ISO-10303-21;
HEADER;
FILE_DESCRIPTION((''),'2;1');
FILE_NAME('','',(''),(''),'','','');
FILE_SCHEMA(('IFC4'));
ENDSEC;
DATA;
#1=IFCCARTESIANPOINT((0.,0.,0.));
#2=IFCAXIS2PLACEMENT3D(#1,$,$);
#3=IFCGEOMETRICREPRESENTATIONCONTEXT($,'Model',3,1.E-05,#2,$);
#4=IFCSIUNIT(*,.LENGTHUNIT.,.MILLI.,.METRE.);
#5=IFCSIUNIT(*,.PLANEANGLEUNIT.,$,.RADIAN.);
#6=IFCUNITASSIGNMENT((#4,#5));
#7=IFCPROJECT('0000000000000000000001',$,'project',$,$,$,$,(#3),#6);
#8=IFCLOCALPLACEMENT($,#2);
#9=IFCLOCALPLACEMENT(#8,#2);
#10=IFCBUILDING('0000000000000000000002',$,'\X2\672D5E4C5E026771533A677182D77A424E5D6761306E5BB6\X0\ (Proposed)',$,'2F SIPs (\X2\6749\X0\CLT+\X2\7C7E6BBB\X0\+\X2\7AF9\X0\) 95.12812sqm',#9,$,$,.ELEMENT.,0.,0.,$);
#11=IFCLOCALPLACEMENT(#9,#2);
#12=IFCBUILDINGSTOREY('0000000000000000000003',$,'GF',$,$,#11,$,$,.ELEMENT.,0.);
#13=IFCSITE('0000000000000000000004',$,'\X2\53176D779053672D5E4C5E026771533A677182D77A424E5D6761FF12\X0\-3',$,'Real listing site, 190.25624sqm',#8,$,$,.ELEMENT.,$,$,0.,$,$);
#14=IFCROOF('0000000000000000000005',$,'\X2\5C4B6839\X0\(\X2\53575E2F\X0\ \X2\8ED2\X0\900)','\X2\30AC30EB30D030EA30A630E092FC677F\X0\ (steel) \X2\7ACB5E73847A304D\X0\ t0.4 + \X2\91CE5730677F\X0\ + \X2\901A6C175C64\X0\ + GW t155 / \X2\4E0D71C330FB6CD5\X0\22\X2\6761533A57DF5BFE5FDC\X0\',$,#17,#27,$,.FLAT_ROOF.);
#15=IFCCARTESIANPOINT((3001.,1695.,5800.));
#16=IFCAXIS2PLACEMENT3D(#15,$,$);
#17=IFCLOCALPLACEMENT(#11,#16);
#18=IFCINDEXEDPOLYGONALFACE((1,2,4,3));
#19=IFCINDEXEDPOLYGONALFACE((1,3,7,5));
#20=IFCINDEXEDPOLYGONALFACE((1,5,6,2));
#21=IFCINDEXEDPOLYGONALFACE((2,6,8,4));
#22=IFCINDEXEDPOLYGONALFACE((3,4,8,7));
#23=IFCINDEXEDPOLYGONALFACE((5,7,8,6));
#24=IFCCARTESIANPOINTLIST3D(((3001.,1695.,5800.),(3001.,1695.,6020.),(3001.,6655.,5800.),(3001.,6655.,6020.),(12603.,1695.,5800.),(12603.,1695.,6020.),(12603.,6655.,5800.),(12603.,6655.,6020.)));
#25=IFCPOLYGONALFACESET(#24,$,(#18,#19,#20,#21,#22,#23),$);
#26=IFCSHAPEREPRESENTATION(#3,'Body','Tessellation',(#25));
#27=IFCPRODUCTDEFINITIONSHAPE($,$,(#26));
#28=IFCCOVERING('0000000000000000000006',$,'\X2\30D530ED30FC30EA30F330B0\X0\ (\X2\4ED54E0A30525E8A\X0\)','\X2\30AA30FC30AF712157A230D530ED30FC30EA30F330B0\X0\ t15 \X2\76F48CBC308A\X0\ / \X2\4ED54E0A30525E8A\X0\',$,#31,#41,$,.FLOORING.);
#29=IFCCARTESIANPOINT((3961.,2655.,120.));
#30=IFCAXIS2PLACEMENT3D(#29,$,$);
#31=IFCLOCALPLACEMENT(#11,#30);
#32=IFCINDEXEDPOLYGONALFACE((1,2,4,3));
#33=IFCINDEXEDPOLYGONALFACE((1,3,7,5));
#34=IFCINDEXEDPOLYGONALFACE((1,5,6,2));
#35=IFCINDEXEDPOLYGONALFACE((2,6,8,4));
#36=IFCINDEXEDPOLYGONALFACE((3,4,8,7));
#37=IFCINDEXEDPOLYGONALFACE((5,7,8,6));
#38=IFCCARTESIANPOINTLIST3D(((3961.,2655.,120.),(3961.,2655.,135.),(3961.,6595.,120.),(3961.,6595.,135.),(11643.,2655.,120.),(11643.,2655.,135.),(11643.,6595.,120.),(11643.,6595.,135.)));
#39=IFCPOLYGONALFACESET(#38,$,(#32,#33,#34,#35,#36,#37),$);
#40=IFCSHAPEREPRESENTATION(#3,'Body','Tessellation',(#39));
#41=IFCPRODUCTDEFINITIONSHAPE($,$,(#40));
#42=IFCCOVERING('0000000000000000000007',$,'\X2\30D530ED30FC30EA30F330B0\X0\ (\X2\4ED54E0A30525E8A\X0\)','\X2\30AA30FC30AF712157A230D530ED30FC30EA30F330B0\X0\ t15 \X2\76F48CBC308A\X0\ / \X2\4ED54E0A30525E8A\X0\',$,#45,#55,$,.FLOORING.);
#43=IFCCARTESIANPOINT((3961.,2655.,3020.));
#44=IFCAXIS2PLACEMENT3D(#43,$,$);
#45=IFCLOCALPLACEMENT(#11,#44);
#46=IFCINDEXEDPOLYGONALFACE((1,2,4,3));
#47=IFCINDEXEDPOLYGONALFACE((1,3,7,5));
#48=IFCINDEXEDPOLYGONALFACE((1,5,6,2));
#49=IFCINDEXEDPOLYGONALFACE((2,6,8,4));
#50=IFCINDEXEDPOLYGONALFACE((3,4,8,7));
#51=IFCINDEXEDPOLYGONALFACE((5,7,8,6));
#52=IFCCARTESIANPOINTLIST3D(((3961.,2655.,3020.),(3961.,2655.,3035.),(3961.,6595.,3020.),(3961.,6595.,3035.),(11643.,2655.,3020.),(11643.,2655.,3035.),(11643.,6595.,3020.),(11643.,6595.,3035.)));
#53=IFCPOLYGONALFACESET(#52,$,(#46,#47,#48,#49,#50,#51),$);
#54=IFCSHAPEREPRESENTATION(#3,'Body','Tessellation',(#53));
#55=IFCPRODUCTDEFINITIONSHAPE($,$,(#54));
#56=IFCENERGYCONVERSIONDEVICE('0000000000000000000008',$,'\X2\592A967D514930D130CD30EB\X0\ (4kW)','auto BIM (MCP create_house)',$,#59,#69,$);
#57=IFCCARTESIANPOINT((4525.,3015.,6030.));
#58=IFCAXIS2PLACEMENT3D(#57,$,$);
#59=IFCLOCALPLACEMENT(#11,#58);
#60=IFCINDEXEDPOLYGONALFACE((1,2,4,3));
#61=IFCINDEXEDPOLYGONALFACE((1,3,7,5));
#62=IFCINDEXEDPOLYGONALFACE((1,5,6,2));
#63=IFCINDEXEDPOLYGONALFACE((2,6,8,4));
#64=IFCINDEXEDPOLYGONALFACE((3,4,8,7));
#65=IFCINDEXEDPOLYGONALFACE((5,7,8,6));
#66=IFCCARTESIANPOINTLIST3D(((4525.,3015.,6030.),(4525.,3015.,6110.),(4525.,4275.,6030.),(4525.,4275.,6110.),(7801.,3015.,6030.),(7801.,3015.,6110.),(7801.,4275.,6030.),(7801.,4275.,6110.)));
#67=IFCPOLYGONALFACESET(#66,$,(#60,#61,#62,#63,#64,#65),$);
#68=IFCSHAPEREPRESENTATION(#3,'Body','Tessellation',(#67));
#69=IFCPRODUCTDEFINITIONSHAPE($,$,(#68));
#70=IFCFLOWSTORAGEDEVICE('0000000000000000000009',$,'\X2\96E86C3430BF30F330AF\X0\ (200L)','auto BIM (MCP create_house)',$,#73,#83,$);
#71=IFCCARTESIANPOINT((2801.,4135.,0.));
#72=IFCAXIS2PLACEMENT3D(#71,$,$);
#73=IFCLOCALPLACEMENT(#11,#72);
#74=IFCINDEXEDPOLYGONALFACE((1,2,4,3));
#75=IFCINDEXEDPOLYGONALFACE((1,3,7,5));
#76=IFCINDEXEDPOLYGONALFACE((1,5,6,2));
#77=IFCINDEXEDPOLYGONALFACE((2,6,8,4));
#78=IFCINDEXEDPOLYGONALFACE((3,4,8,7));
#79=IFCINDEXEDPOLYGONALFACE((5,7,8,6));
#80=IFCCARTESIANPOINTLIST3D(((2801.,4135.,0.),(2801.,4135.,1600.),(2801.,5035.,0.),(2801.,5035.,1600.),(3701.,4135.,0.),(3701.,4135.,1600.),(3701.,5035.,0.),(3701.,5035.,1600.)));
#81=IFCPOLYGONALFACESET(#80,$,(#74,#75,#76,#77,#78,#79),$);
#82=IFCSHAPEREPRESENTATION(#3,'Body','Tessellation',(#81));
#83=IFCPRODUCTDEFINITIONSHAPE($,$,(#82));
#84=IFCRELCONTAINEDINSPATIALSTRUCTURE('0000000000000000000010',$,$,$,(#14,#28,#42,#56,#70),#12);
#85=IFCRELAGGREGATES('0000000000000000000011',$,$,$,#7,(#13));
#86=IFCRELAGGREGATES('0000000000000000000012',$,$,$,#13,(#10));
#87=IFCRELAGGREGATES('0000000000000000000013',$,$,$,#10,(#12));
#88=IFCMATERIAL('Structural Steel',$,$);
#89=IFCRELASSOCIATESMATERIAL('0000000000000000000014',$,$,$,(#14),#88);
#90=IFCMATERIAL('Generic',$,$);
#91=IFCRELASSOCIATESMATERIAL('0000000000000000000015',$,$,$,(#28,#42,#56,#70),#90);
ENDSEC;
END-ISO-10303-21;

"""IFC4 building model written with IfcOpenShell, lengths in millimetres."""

from ifc_helpers import new_model, si_unit, frame, frame_2d, origin, place, context, project, spatial, rectangle, extrude, material, element, save


model = new_model("IFC4")

# Units and contexts
model_context = context("Model", 3, precision=1e-05, world=origin())
ifc_project = project(units=[si_unit("LENGTHUNIT", "METRE", prefix="MILLI"), si_unit("PLANEANGLEUNIT", "RADIAN")], contexts=[model_context])

# Site, building, storey
site_placement = place(None, origin())
site = spatial("IfcSite", under=ifc_project, at=site_placement, Name="北海道札幌市東区東苗穂九条２-3", ObjectType="Real listing site, 190.25624sqm", CompositionType="ELEMENT", RefElevation=0.0)
building_placement = place(site_placement, origin())
building = spatial("IfcBuilding", under=site, at=building_placement, Name="札幌市東区東苗穂九条の家 (Proposed)", ObjectType="2F SIPs (杉CLT+籾殻+竹) 95.12812sqm", CompositionType="ELEMENT", ElevationOfRefHeight=0.0, ElevationOfTerrain=0.0)
storey_placement = place(building_placement, origin())
storey = spatial("IfcBuildingStorey", under=building, at=storey_placement, Name="GF", CompositionType="ELEMENT", Elevation=0.0)

# Roof
ifc_material_1 = material(Name="Structural Steel")
for number, where, name in (
    (1, (3001.0, 1695.0, 5800.0), "屋根(南帯 軒900)"),
):
    element("IfcRoof", number, at=place(storey_placement, frame(where)), inside=storey, material=ifc_material_1, Name=name, Description="ガルバリウム鋼板 (steel) 立平葺き t0.4 + 野地板 + 通気層 + GW t155 / 不燃・法22条区域対応", PredefinedType="FLAT_ROOF", context=model_context, shape_type="SweptSolid", body=[
        extrude(rectangle(XDim=9602.0, YDim=4960.0, at=frame_2d((4801.0, 2480.0))), frame((3001.0, 1695.0, 5800.0)), (0.0, 0.0, 1.0), 220.0),
    ])

# Coverings
ifc_material_2 = material(Name="Generic")
covering_1_placement = place(storey_placement, frame((3961.0, 2655.0, 120.0)))
element("IfcCovering", 2, at=covering_1_placement, inside=storey, material=ifc_material_2, Name="フローリング (仕上げ床)", Description="オーク無垢フローリング t15 直貼り / 仕上げ床", PredefinedType="FLOORING", context=model_context, shape_type="SweptSolid", body=[
    extrude(rectangle(XDim=7682.0, YDim=3940.0, at=frame_2d((3841.0, 1970.0))), frame((3961.0, 2655.0, 120.0)), (0.0, 0.0, 1.0), 15.0),
])
covering_2_placement = place(storey_placement, frame((3961.0, 2655.0, 3020.0)))
element("IfcCovering", 3, at=covering_2_placement, inside=storey, material=ifc_material_2, Name="フローリング (仕上げ床)", Description="オーク無垢フローリング t15 直貼り / 仕上げ床", PredefinedType="FLOORING", context=model_context, shape_type="SweptSolid", body=[
    extrude(rectangle(XDim=7682.0, YDim=3940.0, at=frame_2d((3841.0, 1970.0))), frame((3961.0, 2655.0, 3020.0)), (0.0, 0.0, 1.0), 15.0),
])

# Energy conversion device
energy_conversion_device_placement = place(storey_placement, frame((4525.0, 3015.0, 6030.0)))
element("IfcEnergyConversionDevice", 4, at=energy_conversion_device_placement, inside=storey, material=ifc_material_2, Name="太陽光パネル (4kW)", Description="auto BIM (MCP create_house)", context=model_context, shape_type="SweptSolid", body=[
    extrude(rectangle(XDim=3276.0, YDim=1260.0, at=frame_2d((1638.0, 630.0))), frame((4525.0, 3015.0, 6030.0)), (0.0, 0.0, 1.0), 80.0),
])

# Flow storage device
flow_storage_device_placement = place(storey_placement, frame((2801.0, 4135.0, 0.0)))
element("IfcFlowStorageDevice", 5, at=flow_storage_device_placement, inside=storey, material=ifc_material_2, Name="雨水タンク (200L)", Description="auto BIM (MCP create_house)", context=model_context, shape_type="SweptSolid", body=[
    extrude(rectangle(XDim=900.0, YDim=900.0, at=frame_2d((450.0, 450.0))), frame((2801.0, 4135.0, 0.0)), (0.0, 0.0, 1.0), 1600.0),
])

save(model, "model.ifc")
